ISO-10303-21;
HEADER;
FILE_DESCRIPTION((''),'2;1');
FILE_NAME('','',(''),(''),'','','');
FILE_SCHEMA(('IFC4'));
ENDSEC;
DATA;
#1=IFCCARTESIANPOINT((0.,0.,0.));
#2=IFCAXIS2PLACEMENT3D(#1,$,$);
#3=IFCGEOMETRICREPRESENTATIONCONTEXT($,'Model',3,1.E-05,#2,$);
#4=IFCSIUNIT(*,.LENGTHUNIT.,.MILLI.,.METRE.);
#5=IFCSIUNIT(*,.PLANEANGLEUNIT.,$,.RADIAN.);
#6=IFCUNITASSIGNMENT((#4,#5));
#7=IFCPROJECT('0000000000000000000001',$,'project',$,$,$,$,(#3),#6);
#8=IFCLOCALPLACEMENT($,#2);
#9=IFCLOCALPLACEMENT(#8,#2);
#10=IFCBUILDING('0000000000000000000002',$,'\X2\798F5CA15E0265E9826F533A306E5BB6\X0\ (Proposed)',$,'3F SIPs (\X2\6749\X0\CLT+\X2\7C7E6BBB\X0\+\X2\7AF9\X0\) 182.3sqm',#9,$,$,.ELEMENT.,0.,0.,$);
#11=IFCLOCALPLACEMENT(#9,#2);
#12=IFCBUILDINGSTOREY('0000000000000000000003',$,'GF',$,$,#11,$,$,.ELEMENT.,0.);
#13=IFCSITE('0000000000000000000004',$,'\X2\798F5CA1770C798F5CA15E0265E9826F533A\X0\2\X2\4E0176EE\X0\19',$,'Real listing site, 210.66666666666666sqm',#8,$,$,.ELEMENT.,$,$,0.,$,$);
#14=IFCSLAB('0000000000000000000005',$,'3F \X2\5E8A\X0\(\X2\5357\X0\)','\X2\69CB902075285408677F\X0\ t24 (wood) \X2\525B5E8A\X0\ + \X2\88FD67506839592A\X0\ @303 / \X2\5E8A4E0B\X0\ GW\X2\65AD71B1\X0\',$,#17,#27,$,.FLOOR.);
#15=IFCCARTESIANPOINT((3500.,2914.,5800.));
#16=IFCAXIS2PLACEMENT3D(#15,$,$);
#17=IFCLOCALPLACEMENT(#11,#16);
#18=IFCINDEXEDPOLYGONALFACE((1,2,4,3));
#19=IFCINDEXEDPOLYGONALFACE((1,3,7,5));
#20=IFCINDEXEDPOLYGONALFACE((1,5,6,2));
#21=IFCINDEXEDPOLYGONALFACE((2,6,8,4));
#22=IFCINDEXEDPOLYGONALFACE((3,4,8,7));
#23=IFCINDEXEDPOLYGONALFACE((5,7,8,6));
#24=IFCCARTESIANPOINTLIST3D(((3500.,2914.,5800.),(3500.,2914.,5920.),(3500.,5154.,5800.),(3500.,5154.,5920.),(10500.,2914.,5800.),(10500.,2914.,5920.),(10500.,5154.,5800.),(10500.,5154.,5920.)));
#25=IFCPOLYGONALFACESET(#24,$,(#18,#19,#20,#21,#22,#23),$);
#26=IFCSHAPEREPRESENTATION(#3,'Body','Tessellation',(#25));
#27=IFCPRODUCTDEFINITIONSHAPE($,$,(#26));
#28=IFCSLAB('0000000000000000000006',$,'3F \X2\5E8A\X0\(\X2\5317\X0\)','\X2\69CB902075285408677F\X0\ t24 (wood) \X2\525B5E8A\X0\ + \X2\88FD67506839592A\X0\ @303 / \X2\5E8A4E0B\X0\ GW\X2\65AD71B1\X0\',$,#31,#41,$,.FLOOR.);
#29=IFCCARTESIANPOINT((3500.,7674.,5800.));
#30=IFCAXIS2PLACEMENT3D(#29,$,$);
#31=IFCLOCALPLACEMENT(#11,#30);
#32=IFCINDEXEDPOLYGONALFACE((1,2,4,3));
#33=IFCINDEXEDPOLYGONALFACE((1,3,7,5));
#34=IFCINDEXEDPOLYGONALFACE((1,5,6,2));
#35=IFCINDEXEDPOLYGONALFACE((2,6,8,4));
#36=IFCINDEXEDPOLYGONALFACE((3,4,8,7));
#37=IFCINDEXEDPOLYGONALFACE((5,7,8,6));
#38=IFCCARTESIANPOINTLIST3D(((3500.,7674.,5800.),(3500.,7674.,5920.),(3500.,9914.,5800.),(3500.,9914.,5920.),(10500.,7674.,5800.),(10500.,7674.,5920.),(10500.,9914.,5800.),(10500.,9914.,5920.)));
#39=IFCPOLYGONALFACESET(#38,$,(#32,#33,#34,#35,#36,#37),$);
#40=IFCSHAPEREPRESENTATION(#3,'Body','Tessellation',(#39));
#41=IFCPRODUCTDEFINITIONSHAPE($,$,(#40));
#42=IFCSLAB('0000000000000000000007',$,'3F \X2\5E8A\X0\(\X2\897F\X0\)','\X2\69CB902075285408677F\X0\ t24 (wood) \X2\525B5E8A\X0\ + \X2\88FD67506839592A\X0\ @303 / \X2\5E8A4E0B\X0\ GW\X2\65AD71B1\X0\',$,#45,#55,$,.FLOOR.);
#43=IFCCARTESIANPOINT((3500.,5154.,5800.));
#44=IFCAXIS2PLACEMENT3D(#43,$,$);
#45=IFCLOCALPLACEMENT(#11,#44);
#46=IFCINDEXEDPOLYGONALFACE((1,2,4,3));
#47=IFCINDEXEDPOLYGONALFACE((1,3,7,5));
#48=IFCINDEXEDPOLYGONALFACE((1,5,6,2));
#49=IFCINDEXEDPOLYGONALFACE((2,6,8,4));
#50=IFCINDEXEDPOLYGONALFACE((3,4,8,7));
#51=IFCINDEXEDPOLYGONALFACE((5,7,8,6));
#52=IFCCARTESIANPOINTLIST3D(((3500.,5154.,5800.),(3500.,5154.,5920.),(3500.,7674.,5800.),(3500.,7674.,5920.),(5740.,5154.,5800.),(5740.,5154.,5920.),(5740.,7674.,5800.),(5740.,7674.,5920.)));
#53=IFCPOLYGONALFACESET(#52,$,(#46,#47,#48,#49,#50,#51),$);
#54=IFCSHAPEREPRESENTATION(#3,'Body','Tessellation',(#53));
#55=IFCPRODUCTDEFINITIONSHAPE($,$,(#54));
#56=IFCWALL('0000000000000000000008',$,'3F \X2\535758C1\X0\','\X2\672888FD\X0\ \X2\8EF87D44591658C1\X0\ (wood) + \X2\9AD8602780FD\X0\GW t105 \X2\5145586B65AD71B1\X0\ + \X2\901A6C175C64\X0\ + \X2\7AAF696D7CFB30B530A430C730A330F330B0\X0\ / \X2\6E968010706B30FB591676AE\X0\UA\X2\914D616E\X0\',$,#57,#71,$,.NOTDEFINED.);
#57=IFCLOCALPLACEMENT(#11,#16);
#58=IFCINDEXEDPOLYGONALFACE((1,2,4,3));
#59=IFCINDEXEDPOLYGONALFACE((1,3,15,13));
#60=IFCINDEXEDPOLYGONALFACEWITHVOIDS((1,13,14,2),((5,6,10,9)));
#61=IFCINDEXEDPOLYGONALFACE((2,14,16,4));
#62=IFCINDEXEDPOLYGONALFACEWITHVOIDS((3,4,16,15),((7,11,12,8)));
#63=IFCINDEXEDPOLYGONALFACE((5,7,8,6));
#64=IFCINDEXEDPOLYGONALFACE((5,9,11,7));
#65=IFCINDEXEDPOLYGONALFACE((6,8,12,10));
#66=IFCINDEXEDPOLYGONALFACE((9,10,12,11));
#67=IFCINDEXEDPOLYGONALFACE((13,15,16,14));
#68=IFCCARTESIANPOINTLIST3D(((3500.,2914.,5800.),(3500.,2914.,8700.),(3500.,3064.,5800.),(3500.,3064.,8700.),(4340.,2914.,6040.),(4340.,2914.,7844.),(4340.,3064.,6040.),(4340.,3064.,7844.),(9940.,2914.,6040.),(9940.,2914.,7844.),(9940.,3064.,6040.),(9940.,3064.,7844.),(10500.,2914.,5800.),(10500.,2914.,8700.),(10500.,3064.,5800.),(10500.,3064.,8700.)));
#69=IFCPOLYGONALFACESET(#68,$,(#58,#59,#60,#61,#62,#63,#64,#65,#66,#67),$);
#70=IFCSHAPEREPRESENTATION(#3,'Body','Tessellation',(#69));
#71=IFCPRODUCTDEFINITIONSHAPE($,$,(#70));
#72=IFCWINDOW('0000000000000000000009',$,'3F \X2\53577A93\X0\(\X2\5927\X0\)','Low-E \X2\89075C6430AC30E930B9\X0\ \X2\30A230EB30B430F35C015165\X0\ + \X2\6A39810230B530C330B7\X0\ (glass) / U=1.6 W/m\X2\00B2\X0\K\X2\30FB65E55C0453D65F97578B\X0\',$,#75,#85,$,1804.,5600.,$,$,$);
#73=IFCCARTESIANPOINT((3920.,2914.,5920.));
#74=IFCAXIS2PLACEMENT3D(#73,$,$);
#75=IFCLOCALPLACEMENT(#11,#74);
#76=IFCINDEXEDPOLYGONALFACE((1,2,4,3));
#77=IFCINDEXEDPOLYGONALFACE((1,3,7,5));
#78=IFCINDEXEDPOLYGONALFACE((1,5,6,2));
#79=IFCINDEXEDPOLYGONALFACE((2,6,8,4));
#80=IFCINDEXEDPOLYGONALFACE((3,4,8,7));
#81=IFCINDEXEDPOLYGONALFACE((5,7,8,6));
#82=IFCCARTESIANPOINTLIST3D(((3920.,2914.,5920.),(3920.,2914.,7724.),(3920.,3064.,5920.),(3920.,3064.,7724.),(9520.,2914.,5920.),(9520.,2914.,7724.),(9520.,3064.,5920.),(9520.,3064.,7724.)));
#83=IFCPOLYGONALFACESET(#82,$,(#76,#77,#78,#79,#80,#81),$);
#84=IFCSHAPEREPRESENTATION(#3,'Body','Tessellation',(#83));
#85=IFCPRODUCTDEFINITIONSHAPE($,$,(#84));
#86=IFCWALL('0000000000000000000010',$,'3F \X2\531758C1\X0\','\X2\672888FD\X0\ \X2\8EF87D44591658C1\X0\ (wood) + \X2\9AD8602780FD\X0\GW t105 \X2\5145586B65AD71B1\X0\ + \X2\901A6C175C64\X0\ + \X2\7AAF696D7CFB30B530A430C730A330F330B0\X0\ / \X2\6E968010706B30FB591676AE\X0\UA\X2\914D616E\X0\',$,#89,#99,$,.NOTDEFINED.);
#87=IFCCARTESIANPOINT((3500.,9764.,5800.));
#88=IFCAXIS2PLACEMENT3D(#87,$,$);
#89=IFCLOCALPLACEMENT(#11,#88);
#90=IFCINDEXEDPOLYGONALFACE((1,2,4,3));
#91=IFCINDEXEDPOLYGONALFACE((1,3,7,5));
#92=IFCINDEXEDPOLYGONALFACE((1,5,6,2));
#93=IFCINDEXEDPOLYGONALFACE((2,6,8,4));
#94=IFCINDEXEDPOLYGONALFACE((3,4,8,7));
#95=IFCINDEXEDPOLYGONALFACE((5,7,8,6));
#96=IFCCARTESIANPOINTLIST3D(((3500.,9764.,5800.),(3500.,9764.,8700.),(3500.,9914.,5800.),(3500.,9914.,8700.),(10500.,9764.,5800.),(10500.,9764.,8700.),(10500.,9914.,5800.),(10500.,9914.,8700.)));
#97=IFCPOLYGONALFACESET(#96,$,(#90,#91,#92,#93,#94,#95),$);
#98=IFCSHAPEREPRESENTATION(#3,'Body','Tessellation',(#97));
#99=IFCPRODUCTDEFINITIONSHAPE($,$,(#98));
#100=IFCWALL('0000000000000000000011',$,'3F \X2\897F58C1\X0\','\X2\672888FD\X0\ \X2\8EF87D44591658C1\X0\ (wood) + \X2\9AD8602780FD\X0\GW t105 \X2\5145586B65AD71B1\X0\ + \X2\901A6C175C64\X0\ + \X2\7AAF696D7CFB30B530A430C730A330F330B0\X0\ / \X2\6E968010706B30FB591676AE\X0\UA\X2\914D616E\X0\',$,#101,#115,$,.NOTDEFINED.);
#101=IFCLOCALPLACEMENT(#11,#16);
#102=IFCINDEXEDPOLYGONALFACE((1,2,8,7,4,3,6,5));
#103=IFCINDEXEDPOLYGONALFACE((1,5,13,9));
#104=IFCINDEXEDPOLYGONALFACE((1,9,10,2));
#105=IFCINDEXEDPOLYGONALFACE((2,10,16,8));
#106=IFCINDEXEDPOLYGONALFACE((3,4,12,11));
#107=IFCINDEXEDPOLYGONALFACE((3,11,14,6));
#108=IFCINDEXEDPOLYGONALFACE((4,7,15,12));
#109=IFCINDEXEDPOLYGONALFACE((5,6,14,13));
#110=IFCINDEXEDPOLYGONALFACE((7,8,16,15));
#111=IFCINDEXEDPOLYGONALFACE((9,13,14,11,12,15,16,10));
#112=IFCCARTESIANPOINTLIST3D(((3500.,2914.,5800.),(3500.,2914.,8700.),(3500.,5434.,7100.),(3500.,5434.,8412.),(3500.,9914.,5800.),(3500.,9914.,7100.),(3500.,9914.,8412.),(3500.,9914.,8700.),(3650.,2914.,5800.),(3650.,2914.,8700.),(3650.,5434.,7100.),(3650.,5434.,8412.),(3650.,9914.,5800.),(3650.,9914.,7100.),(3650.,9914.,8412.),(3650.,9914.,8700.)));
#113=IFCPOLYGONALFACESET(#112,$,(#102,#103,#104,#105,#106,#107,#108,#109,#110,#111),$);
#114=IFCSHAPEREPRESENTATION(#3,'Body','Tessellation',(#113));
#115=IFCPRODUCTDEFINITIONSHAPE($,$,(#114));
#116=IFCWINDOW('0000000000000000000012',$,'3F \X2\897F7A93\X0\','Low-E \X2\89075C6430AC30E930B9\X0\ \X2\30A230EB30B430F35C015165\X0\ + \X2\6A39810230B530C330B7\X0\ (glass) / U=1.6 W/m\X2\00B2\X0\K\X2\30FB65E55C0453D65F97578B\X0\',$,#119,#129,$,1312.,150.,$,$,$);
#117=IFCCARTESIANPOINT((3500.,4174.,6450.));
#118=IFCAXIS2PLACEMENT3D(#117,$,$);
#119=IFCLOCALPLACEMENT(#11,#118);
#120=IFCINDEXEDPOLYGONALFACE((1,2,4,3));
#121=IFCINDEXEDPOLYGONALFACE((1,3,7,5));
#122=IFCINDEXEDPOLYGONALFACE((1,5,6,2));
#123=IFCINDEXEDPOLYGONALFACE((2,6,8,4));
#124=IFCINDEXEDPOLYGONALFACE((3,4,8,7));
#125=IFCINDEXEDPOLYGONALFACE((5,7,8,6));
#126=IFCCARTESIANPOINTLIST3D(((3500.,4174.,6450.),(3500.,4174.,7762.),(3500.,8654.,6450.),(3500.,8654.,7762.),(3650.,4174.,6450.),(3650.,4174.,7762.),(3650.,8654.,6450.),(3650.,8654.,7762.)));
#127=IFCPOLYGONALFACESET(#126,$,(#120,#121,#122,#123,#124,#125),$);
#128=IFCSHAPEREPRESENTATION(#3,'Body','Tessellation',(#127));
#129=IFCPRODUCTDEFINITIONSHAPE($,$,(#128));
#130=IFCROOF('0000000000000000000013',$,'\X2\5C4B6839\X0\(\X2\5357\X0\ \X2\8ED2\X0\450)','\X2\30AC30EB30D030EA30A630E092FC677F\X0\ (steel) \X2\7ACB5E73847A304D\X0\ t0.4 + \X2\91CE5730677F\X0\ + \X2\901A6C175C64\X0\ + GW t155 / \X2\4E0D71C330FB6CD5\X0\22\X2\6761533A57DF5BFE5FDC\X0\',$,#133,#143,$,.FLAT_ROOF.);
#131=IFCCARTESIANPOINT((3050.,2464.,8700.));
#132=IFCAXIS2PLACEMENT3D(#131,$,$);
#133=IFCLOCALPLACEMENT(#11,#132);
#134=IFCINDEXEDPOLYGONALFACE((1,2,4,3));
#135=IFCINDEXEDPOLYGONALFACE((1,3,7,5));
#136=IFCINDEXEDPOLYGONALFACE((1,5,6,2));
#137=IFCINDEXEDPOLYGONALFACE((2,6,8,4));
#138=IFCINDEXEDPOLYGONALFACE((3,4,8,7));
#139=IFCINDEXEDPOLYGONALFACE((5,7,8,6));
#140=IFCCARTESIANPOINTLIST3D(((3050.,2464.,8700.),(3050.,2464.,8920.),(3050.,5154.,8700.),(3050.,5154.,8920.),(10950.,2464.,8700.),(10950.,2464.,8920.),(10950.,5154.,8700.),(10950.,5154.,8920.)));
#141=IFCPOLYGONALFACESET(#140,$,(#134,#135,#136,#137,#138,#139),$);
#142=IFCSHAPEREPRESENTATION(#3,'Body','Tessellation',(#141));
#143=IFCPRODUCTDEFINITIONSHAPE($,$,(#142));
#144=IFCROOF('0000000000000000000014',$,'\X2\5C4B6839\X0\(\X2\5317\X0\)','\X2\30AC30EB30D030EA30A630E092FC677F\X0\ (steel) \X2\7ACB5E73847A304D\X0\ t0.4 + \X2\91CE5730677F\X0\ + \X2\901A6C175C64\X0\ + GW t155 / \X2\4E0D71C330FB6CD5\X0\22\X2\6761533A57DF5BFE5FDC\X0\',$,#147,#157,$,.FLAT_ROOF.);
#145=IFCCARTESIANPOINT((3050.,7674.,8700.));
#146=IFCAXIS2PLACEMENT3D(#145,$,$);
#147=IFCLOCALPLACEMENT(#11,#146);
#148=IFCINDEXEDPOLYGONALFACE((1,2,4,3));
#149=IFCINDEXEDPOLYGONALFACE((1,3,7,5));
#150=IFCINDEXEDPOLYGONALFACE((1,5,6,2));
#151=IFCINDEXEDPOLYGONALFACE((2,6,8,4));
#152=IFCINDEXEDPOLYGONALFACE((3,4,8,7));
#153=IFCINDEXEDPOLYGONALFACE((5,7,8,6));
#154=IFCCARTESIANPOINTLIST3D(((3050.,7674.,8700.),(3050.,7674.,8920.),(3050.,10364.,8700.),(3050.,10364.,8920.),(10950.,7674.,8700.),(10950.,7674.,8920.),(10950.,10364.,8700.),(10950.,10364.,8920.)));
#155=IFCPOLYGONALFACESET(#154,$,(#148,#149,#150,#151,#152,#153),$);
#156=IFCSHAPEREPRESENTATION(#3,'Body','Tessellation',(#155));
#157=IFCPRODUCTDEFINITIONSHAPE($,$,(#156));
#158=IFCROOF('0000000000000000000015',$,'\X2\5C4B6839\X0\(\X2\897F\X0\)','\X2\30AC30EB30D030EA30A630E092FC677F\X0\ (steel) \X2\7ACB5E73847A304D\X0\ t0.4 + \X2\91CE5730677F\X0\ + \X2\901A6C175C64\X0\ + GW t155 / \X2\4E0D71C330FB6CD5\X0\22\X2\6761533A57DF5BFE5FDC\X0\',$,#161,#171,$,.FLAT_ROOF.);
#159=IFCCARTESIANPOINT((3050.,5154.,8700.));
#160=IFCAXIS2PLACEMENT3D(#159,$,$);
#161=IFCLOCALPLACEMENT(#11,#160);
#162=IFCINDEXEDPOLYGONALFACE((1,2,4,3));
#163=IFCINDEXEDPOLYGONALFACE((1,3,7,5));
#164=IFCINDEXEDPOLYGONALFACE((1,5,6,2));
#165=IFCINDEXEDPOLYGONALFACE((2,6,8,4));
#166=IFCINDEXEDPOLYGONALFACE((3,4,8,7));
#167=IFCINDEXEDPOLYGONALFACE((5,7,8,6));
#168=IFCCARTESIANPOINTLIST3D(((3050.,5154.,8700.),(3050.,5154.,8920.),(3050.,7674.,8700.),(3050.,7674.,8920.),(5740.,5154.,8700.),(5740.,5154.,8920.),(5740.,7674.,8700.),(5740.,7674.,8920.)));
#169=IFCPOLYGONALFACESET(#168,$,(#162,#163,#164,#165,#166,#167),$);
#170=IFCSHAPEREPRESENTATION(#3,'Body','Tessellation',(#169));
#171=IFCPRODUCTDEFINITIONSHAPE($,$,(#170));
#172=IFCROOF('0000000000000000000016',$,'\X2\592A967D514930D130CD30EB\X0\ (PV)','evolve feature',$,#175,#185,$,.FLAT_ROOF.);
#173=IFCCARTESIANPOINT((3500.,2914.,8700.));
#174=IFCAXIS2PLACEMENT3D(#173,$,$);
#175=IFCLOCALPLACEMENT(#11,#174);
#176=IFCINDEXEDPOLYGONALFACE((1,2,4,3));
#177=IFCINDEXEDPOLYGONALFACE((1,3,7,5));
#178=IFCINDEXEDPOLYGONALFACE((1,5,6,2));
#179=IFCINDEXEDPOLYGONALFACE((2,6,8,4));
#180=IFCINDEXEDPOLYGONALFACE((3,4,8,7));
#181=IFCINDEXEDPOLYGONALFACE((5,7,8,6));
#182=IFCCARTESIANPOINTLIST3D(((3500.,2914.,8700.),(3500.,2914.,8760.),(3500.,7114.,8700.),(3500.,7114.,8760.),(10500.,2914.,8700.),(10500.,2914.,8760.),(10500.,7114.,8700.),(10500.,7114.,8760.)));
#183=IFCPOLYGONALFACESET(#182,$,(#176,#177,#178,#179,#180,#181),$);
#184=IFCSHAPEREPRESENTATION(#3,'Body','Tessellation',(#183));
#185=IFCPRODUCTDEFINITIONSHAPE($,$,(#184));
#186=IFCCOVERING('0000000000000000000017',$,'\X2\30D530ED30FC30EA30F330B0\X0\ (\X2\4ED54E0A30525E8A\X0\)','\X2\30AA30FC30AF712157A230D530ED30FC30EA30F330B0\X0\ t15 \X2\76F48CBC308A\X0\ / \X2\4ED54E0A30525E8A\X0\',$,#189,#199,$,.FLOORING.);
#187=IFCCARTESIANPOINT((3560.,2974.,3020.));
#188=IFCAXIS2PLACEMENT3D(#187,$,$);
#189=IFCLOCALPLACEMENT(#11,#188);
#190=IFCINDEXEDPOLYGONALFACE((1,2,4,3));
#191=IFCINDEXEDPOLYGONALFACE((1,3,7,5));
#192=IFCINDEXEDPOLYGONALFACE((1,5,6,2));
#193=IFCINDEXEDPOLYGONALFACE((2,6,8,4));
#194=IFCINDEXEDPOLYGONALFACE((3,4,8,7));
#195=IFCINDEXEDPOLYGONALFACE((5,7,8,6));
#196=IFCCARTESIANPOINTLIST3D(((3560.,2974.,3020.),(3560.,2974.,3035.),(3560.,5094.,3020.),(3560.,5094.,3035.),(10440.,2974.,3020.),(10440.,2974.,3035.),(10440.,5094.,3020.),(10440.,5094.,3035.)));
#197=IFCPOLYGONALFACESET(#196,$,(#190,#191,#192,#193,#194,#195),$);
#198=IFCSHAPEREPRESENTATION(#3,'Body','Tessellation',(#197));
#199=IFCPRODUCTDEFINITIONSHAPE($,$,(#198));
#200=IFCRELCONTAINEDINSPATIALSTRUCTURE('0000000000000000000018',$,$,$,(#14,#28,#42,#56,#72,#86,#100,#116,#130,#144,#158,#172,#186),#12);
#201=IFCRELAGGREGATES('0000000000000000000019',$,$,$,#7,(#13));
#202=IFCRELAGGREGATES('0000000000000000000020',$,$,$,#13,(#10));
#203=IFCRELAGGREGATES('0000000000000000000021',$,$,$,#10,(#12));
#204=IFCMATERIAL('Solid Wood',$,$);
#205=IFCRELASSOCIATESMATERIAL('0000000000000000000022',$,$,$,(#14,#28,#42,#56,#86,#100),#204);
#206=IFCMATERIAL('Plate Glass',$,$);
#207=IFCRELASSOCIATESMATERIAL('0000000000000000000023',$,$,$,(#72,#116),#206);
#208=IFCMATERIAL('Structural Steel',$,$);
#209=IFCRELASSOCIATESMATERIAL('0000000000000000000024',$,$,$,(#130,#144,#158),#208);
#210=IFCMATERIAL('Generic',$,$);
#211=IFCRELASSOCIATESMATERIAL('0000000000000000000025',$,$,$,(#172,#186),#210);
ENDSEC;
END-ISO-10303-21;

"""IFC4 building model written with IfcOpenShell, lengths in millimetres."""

from ifc_helpers import new_model, si_unit, frame, frame_2d, origin, place, context, project, spatial, rectangle, extrude, material, element, fill, save


model = new_model("IFC4")

# Units and contexts
model_context = context("Model", 3, precision=1e-05, world=origin())
ifc_project = project(units=[si_unit("LENGTHUNIT", "METRE", prefix="MILLI"), si_unit("PLANEANGLEUNIT", "RADIAN")], contexts=[model_context])

# Site, building, storey
site_placement = place(None, origin())
site = spatial("IfcSite", under=ifc_project, at=site_placement, Name="福岡県福岡市早良区2丁目19", ObjectType="Real listing site, 210.66666666666666sqm", CompositionType="ELEMENT", RefElevation=0.0)
building_placement = place(site_placement, origin())
building = spatial("IfcBuilding", under=site, at=building_placement, Name="福岡市早良区の家 (Proposed)", ObjectType="3F SIPs (杉CLT+籾殻+竹) 182.3sqm", CompositionType="ELEMENT", ElevationOfRefHeight=0.0, ElevationOfTerrain=0.0)
storey_placement = place(building_placement, origin())
storey = spatial("IfcBuildingStorey", under=building, at=storey_placement, Name="GF", CompositionType="ELEMENT", Elevation=0.0)

# Slabs
ifc_material_1 = material(Name="Solid Wood")
slab_1_placement = place(storey_placement, frame((3500.0, 2914.0, 5800.0)))
element("IfcSlab", 1, at=slab_1_placement, inside=storey, material=ifc_material_1, Name="3F 床(南)", Description="構造用合板 t24 (wood) 剛床 + 製材根太 @303 / 床下 GW断熱", PredefinedType="FLOOR", context=model_context, shape_type="SweptSolid", body=[
    extrude(rectangle(XDim=7000.0, YDim=2240.0, at=frame_2d((3500.0, 1120.0))), frame((3500.0, 2914.0, 5800.0)), (0.0, 0.0, 1.0), 120.0),
])
slab_2_placement = place(storey_placement, frame((3500.0, 7674.0, 5800.0)))
element("IfcSlab", 2, at=slab_2_placement, inside=storey, material=ifc_material_1, Name="3F 床(北)", Description="構造用合板 t24 (wood) 剛床 + 製材根太 @303 / 床下 GW断熱", PredefinedType="FLOOR", context=model_context, shape_type="SweptSolid", body=[
    extrude(rectangle(XDim=7000.0, YDim=2240.0, at=frame_2d((3500.0, 1120.0))), frame((3500.0, 7674.0, 5800.0)), (0.0, 0.0, 1.0), 120.0),
])
slab_3_placement = place(storey_placement, frame((3500.0, 5154.0, 5800.0)))
element("IfcSlab", 3, at=slab_3_placement, inside=storey, material=ifc_material_1, Name="3F 床(西)", Description="構造用合板 t24 (wood) 剛床 + 製材根太 @303 / 床下 GW断熱", PredefinedType="FLOOR", context=model_context, shape_type="SweptSolid", body=[
    extrude(rectangle(XDim=2240.0, YDim=2520.0, at=frame_2d((1120.0, 1260.0))), frame((3500.0, 5154.0, 5800.0)), (0.0, 0.0, 1.0), 120.0),
])

# Wall, opening, window
wall_1_placement = place(storey_placement, frame((3500.0, 2914.0, 5800.0)))
wall_1 = element("IfcWall", 4, at=wall_1_placement, inside=storey, material=ifc_material_1, Name="3F 南壁", Description="木製 軸組外壁 (wood) + 高性能GW t105 充填断熱 + 通気層 + 窯業系サイディング / 準耐火・外皮UA配慮", PredefinedType="NOTDEFINED", context=model_context, shape_type="SweptSolid", body=[
    extrude(rectangle(XDim=7000.0, YDim=150.0, at=frame_2d((3500.0, 75.0))), frame((3500.0, 2914.0, 5800.0)), (0.0, 0.0, 1.0), 2900.0),
])
opening_1_placement = place(storey_placement, frame((3920.0, 2914.0, 5920.0)))
opening_1 = element("IfcOpeningElement", 5, at=opening_1_placement, cuts=wall_1, PredefinedType="NOTDEFINED", context=model_context, shape_type="SweptSolid", body=[
    extrude(rectangle(XDim=5600.0, YDim=150.0, at=frame_2d((2800.0, 75.0))), frame((3920.0, 2914.0, 5920.0)), (0.0, 0.0, 1.0), 1804.0),
])
ifc_material_2 = material(Name="Plate Glass")
window_1_placement = place(storey_placement, frame((3920.0, 2914.0, 5920.0)))
window_1 = element("IfcWindow", 6, at=window_1_placement, inside=storey, material=ifc_material_2, Name="3F 南窓(大)", Description="Low-E 複層ガラス アルゴン封入 + 樹脂サッシ (glass) / U=1.6 W/m²K・日射取得型", OverallHeight=1804.0, OverallWidth=5600.0, context=model_context, shape_type="SweptSolid", body=[
    extrude(rectangle(XDim=5600.0, YDim=150.0, at=frame_2d((2800.0, 75.0))), frame((3920.0, 2914.0, 5920.0)), (0.0, 0.0, 1.0), 1804.0),
])
fill(opening_1, window_1)

# Wall
wall_2_placement = place(storey_placement, frame((3500.0, 9764.0, 5800.0)))
element("IfcWall", 7, at=wall_2_placement, inside=storey, material=ifc_material_1, Name="3F 北壁", Description="木製 軸組外壁 (wood) + 高性能GW t105 充填断熱 + 通気層 + 窯業系サイディング / 準耐火・外皮UA配慮", PredefinedType="NOTDEFINED", context=model_context, shape_type="SweptSolid", body=[
    extrude(rectangle(XDim=7000.0, YDim=150.0, at=frame_2d((3500.0, 75.0))), frame((3500.0, 9764.0, 5800.0)), (0.0, 0.0, 1.0), 2900.0),
])

# Wall, opening, window
wall_3_placement = place(storey_placement, frame((3500.0, 2914.0, 5800.0)))
wall_3 = element("IfcWall", 8, at=wall_3_placement, inside=storey, material=ifc_material_1, Name="3F 西壁", Description="木製 軸組外壁 (wood) + 高性能GW t105 充填断熱 + 通気層 + 窯業系サイディング / 準耐火・外皮UA配慮", PredefinedType="NOTDEFINED", context=model_context, shape_type="SweptSolid", body=[
    extrude(rectangle(XDim=150.0, YDim=7000.0, at=frame_2d((75.0, 3500.0))), frame((3500.0, 2914.0, 5800.0)), (0.0, 0.0, 1.0), 2900.0),
])
opening_2_placement = place(storey_placement, frame((3500.0, 4174.0, 6450.0)))
opening_2 = element("IfcOpeningElement", 9, at=opening_2_placement, cuts=wall_3, PredefinedType="NOTDEFINED", context=model_context, shape_type="SweptSolid", body=[
    extrude(rectangle(XDim=150.0, YDim=4480.0, at=frame_2d((75.0, 2240.0))), frame((3500.0, 4174.0, 6450.0)), (0.0, 0.0, 1.0), 1312.0),
])
window_2_placement = place(storey_placement, frame((3500.0, 4174.0, 6450.0)))
window_2 = element("IfcWindow", 10, at=window_2_placement, inside=storey, material=ifc_material_2, Name="3F 西窓", Description="Low-E 複層ガラス アルゴン封入 + 樹脂サッシ (glass) / U=1.6 W/m²K・日射取得型", OverallHeight=1312.0, OverallWidth=150.0, context=model_context, shape_type="SweptSolid", body=[
    extrude(rectangle(XDim=150.0, YDim=4480.0, at=frame_2d((75.0, 2240.0))), frame((3500.0, 4174.0, 6450.0)), (0.0, 0.0, 1.0), 1312.0),
])
fill(opening_2, window_2)

# Roofs
ifc_material_3 = material(Name="Structural Steel")
roof_1_placement = place(storey_placement, frame((3050.0, 2464.0, 8700.0)))
element("IfcRoof", 11, at=roof_1_placement, inside=storey, material=ifc_material_3, Name="屋根(南 軒450)", Description="ガルバリウム鋼板 (steel) 立平葺き t0.4 + 野地板 + 通気層 + GW t155 / 不燃・法22条区域対応", PredefinedType="FLAT_ROOF", context=model_context, shape_type="SweptSolid", body=[
    extrude(rectangle(XDim=7900.0, YDim=2690.0, at=frame_2d((3950.0, 1345.0))), frame((3050.0, 2464.0, 8700.0)), (0.0, 0.0, 1.0), 220.0),
])
roof_2_placement = place(storey_placement, frame((3050.0, 7674.0, 8700.0)))
element("IfcRoof", 12, at=roof_2_placement, inside=storey, material=ifc_material_3, Name="屋根(北)", Description="ガルバリウム鋼板 (steel) 立平葺き t0.4 + 野地板 + 通気層 + GW t155 / 不燃・法22条区域対応", PredefinedType="FLAT_ROOF", context=model_context, shape_type="SweptSolid", body=[
    extrude(rectangle(XDim=7900.0, YDim=2690.0, at=frame_2d((3950.0, 1345.0))), frame((3050.0, 7674.0, 8700.0)), (0.0, 0.0, 1.0), 220.0),
])
roof_3_placement = place(storey_placement, frame((3050.0, 5154.0, 8700.0)))
element("IfcRoof", 13, at=roof_3_placement, inside=storey, material=ifc_material_3, Name="屋根(西)", Description="ガルバリウム鋼板 (steel) 立平葺き t0.4 + 野地板 + 通気層 + GW t155 / 不燃・法22条区域対応", PredefinedType="FLAT_ROOF", context=model_context, shape_type="SweptSolid", body=[
    extrude(rectangle(XDim=2690.0, YDim=2520.0, at=frame_2d((1345.0, 1260.0))), frame((3050.0, 5154.0, 8700.0)), (0.0, 0.0, 1.0), 220.0),
])
ifc_material_4 = material(Name="Generic")
roof_4_placement = place(storey_placement, frame((3500.0, 2914.0, 8700.0)))
element("IfcRoof", 14, at=roof_4_placement, inside=storey, material=ifc_material_4, Name="太陽光パネル (PV)", Description="evolve feature", PredefinedType="FLAT_ROOF", context=model_context, shape_type="SweptSolid", body=[
    extrude(rectangle(XDim=7000.0, YDim=4200.0, at=frame_2d((3500.0, 2100.0))), frame((3500.0, 2914.0, 8700.0)), (0.0, 0.0, 1.0), 60.0),
])

# Covering
covering_1_placement = place(storey_placement, frame((3560.0, 2974.0, 3020.0)))
element("IfcCovering", 15, at=covering_1_placement, inside=storey, material=ifc_material_4, Name="フローリング (仕上げ床)", Description="オーク無垢フローリング t15 直貼り / 仕上げ床", PredefinedType="FLOORING", context=model_context, shape_type="SweptSolid", body=[
    extrude(rectangle(XDim=6880.0, YDim=2120.0, at=frame_2d((3440.0, 1060.0))), frame((3560.0, 2974.0, 3020.0)), (0.0, 0.0, 1.0), 15.0),
])

save(model, "model.ifc")
